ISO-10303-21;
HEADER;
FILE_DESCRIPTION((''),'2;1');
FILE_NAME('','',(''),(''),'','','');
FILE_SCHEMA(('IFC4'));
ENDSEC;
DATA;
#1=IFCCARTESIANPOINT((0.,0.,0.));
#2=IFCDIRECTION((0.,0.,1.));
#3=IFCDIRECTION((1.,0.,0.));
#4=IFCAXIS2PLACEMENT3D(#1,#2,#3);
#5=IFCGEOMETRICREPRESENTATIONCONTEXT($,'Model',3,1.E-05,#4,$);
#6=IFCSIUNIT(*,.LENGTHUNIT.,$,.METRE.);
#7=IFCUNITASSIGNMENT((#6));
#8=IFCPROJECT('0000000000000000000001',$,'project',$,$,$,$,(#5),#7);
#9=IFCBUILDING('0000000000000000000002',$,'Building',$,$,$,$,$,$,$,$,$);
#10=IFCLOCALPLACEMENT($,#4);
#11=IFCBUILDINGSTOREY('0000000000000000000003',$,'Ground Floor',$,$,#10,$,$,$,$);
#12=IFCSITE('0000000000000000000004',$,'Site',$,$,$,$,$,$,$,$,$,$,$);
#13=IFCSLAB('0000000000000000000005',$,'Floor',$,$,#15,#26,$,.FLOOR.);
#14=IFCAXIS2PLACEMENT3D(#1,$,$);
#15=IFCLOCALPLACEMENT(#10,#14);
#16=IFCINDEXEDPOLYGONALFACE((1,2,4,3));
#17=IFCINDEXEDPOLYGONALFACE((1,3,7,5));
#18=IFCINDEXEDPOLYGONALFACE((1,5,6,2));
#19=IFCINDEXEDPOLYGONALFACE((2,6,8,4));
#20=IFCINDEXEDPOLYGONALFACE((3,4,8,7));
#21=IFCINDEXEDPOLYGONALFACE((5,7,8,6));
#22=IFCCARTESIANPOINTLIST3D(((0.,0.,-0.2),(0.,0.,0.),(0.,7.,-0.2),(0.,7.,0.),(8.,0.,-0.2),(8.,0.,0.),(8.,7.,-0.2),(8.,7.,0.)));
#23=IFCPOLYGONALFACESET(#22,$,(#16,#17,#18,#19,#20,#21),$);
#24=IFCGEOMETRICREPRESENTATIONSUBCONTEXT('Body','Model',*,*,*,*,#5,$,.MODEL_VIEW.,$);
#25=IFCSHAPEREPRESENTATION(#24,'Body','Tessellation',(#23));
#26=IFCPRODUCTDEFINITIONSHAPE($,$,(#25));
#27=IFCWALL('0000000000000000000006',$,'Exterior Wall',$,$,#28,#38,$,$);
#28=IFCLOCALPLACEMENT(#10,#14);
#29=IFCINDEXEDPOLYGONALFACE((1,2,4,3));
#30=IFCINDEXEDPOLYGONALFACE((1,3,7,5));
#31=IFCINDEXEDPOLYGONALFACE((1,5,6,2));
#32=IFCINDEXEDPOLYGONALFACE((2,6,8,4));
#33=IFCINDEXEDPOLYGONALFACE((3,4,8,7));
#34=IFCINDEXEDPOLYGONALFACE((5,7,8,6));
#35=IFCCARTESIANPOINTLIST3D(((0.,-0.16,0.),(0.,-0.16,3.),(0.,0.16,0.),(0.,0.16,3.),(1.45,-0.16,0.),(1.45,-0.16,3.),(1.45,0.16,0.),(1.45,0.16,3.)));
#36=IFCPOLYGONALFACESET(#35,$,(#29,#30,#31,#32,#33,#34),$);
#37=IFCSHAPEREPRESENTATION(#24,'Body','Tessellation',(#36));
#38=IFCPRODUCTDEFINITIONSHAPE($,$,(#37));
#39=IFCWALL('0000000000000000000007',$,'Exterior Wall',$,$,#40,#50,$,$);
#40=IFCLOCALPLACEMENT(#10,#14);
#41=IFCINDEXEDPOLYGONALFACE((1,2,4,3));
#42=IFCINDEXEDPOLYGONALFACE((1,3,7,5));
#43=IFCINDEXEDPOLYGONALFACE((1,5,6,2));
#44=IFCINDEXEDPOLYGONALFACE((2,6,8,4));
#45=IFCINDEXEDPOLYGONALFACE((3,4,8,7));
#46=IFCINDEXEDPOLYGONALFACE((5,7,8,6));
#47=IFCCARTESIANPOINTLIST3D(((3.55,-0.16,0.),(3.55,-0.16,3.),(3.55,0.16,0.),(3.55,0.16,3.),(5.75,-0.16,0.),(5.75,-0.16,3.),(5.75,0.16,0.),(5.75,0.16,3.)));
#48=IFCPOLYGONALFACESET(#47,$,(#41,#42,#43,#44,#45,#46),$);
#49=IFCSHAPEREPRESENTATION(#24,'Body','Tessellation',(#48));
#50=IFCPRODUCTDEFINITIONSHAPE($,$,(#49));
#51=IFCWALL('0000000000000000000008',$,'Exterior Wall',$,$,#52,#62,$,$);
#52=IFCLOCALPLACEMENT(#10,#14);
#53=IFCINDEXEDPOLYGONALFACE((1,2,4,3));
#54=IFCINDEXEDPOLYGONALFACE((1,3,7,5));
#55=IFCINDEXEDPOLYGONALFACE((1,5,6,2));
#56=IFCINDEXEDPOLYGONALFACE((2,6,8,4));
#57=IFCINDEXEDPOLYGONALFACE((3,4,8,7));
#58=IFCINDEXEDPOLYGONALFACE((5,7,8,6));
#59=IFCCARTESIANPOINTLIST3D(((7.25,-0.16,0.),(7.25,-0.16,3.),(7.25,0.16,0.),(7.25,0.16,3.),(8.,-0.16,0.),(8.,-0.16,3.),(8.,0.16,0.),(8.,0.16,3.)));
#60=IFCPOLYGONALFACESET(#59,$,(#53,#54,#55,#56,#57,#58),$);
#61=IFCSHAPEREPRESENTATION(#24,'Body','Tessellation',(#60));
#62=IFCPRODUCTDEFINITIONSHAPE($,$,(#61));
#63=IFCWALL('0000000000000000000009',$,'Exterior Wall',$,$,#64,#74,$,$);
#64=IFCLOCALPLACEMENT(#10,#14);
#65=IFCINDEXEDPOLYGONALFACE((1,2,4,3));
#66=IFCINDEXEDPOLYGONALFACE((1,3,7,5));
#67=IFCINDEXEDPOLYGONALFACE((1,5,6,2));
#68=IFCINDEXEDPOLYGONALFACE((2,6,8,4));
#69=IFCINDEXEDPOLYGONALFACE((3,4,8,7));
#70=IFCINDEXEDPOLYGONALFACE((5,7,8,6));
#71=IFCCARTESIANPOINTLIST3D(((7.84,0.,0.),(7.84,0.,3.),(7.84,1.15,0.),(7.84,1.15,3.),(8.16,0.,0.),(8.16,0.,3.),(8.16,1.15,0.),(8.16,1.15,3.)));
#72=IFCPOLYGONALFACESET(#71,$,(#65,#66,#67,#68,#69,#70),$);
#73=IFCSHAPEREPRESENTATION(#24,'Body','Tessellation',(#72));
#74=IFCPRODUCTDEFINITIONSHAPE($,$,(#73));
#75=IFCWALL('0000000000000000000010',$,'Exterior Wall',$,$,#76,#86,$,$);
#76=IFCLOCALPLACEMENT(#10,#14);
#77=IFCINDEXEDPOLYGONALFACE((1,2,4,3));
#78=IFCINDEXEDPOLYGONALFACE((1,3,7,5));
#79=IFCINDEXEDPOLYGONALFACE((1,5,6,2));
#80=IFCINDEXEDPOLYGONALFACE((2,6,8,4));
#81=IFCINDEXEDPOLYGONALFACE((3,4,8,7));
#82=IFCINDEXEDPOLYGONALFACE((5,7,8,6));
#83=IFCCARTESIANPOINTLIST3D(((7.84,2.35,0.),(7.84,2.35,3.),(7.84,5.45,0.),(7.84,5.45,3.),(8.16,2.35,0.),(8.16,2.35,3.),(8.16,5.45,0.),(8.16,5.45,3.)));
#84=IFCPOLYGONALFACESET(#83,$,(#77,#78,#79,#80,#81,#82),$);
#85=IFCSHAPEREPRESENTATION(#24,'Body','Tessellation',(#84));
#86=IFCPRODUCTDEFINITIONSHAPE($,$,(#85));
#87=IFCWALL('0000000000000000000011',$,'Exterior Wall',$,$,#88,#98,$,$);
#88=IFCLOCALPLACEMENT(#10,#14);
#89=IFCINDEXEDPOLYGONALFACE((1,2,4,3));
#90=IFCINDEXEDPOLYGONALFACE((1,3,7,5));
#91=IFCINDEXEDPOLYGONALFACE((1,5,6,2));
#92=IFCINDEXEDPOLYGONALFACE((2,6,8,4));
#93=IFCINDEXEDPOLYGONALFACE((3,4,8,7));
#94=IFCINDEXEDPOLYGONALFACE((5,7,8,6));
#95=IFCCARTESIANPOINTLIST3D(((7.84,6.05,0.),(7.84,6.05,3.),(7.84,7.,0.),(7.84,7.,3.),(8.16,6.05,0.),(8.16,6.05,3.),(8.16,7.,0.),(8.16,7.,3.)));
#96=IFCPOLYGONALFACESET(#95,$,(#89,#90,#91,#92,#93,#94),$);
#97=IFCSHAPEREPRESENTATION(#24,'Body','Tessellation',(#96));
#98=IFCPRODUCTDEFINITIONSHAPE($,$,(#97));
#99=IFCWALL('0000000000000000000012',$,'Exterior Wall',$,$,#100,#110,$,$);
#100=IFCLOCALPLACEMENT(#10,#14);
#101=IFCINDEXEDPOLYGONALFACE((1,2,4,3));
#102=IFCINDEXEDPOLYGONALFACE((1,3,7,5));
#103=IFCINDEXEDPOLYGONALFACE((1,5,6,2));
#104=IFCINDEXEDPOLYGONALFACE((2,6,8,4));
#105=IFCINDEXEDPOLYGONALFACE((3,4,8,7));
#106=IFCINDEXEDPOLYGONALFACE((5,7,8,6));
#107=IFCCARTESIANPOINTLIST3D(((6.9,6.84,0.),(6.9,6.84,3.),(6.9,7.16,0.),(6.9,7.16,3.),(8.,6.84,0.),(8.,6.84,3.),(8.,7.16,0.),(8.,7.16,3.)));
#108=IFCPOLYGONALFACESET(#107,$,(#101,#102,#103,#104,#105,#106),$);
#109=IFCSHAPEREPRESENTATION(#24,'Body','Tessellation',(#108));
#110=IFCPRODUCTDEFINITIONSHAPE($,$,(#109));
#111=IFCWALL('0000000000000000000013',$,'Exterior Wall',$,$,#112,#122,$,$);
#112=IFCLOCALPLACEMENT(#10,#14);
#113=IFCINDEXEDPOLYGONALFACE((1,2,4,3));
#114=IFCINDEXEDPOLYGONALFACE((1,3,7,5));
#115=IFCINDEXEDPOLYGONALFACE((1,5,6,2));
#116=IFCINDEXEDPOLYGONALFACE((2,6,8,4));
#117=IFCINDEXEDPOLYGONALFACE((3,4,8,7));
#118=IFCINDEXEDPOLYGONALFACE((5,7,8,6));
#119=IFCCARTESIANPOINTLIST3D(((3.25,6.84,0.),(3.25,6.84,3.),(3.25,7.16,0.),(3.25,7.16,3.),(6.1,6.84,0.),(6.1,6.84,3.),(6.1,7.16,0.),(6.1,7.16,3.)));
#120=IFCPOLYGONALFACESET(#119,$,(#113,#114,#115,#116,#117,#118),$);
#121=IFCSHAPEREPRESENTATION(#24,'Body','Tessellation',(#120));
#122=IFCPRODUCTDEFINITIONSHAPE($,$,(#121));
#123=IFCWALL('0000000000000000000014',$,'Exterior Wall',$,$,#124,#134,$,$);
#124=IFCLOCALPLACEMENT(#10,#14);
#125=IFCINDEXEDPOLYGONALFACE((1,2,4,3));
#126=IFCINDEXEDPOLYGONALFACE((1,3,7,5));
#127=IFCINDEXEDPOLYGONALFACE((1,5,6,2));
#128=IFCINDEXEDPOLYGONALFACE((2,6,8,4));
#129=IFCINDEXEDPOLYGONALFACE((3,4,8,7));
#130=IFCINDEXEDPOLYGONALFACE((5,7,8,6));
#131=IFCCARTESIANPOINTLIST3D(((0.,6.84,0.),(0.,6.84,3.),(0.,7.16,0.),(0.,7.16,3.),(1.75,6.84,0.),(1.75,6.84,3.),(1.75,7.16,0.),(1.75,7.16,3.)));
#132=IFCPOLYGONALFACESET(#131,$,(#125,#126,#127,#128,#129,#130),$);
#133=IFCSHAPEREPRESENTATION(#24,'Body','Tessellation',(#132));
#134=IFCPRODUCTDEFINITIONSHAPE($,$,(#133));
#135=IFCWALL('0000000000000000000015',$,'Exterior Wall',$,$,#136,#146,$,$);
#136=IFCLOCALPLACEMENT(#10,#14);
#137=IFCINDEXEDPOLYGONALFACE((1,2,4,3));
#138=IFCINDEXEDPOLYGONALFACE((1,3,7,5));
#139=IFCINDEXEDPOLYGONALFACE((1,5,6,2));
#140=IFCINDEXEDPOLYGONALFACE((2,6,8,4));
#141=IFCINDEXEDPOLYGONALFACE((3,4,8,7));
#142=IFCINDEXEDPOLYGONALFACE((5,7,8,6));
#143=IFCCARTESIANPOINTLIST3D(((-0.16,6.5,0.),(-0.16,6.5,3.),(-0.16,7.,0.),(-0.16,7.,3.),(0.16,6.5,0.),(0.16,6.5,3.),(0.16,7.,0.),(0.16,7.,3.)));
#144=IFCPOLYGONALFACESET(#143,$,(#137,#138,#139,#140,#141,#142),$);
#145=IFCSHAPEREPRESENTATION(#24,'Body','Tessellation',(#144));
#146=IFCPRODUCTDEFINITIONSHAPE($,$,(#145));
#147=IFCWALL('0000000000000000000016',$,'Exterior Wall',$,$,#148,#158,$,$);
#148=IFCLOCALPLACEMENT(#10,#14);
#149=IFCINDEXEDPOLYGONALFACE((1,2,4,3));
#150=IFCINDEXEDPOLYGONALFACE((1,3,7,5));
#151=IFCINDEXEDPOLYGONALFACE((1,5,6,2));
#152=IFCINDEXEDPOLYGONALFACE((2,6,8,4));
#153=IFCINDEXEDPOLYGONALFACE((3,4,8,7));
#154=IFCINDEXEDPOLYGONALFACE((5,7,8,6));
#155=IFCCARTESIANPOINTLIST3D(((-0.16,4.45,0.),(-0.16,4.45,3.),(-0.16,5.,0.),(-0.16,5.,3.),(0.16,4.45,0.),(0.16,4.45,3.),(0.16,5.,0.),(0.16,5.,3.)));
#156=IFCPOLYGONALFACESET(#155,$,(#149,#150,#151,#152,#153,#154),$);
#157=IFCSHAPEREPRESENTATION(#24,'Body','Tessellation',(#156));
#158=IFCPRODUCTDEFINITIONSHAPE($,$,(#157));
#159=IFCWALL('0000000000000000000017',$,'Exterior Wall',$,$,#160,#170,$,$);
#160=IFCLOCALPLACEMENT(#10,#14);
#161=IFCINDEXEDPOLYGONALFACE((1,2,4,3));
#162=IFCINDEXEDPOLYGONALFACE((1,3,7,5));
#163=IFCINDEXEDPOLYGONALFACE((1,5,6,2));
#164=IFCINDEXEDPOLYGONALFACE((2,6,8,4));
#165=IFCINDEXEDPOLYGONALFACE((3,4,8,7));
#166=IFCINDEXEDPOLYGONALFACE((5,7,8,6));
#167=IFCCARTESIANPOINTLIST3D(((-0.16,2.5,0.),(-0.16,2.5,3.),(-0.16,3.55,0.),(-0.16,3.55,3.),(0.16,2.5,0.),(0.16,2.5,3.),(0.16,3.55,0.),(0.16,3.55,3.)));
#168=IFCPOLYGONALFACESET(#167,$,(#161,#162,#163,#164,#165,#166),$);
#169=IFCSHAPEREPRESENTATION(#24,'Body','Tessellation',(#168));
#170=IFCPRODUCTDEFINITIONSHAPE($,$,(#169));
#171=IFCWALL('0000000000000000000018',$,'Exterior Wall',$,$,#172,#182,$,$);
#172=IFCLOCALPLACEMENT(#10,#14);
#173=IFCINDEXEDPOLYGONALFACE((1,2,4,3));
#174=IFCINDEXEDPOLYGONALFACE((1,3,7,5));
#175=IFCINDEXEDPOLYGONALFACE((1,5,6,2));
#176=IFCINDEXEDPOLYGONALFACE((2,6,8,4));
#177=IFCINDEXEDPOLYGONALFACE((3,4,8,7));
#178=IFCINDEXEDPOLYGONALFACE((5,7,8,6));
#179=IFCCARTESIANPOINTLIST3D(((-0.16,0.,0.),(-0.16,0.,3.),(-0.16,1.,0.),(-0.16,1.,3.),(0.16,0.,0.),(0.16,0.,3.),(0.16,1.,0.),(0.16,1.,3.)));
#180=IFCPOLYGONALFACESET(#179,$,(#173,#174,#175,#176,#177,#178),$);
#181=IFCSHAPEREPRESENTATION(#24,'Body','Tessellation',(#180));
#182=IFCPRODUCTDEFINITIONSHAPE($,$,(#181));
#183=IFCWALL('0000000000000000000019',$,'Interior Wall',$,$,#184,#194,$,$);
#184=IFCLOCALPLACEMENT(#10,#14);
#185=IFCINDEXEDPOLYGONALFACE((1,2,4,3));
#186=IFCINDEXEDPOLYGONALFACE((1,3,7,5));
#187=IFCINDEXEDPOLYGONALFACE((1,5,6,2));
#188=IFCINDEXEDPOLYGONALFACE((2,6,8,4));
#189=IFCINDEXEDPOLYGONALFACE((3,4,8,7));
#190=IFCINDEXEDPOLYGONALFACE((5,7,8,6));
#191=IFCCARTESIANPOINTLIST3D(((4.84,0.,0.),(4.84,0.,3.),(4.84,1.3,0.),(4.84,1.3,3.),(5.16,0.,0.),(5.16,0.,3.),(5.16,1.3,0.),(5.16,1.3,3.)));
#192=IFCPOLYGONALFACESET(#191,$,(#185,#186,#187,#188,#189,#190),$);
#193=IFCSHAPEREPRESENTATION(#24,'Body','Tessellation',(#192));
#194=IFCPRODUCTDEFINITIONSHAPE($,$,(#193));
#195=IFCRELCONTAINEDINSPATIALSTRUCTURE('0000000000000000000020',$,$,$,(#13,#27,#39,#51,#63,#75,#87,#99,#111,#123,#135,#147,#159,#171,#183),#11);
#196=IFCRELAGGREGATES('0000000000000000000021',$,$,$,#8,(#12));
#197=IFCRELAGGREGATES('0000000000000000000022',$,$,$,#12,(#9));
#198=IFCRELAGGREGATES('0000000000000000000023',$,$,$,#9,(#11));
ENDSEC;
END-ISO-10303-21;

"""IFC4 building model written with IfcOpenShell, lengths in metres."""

from ifc_helpers import new_model, si_unit, frame, origin_with_axes, place, context, subcontext, project, spatial, indexed_curve, outline, extrude, element, save


model = new_model("IFC4")

# Units and contexts
model_context = context("Model", 3, precision=1e-05, world=origin_with_axes())
body_context = subcontext(model_context, "Body", "Model", "MODEL_VIEW")
ifc_project = project(units=[si_unit("LENGTHUNIT", "METRE")], contexts=[model_context])

# Site, building, storey
site = spatial("IfcSite", under=ifc_project, Name="Site")
building = spatial("IfcBuilding", under=site, Name="Building")
storey_placement = place(None, origin_with_axes())
storey = spatial("IfcBuildingStorey", under=building, at=storey_placement, Name="Ground Floor")

# Slab
slab_placement = place(storey_placement, frame((0.0, 0.0, -0.2), z_axis=(0.0, 0.0, 1.0), x_axis=(1.0, 0.0, 0.0)))
element("IfcSlab", 1, at=slab_placement, inside=storey, Name="Floor", PredefinedType="FLOOR", context=body_context, shape_type="SweptSolid", body=[
    extrude(outline(indexed_curve([(0.0, 0.0), (8.0, 0.0), (8.0, 7.0), (0.0, 7.0)])), None, (0.0, 0.0, 1.0), 0.2),
])

# Walls
wall_1_placement = place(storey_placement, origin_with_axes())
element("IfcWall", 2, at=wall_1_placement, inside=storey, Name="Exterior Wall", context=body_context, shape_type="SweptSolid", body=[
    extrude(outline(indexed_curve([(0.0, 0.0), (0.0, 0.32), (1.45, 0.32), (1.45, 0.0), (0.0, 0.0)], self_intersect=False)), frame((0.0, -0.16, 0.0), z_axis=(0.0, 0.0, 1.0), x_axis=(1.0, 0.0, 0.0)), (0.0, 0.0, 1.0), 3.0),
])
wall_2_placement = place(storey_placement, frame((3.55, 0.0, 0.0), z_axis=(0.0, 0.0, 1.0), x_axis=(1.0, 0.0, 0.0)))
element("IfcWall", 3, at=wall_2_placement, inside=storey, Name="Exterior Wall", context=body_context, shape_type="SweptSolid", body=[
    extrude(outline(indexed_curve([(0.0, 0.0), (0.0, 0.32), (2.2, 0.32), (2.2, 0.0), (0.0, 0.0)], self_intersect=False)), frame((0.0, -0.16, 0.0), z_axis=(0.0, 0.0, 1.0), x_axis=(1.0, 0.0, 0.0)), (0.0, 0.0, 1.0), 3.0),
])
wall_3_placement = place(storey_placement, frame((7.25, 0.0, 0.0), z_axis=(0.0, 0.0, 1.0), x_axis=(1.0, 0.0, 0.0)))
element("IfcWall", 4, at=wall_3_placement, inside=storey, Name="Exterior Wall", context=body_context, shape_type="SweptSolid", body=[
    extrude(outline(indexed_curve([(0.0, 0.0), (0.0, 0.32), (0.75, 0.32), (0.75, 0.0), (0.0, 0.0)], self_intersect=False)), frame((0.0, -0.16, 0.0), z_axis=(0.0, 0.0, 1.0), x_axis=(1.0, 0.0, 0.0)), (0.0, 0.0, 1.0), 3.0),
])
wall_4_placement = place(storey_placement, frame((8.0, 0.0, 0.0), z_axis=(0.0, 0.0, 1.0), x_axis=(0.0, 1.0, 0.0)))
element("IfcWall", 5, at=wall_4_placement, inside=storey, Name="Exterior Wall", context=body_context, shape_type="SweptSolid", body=[
    extrude(outline(indexed_curve([(0.0, 0.0), (0.0, 0.32), (1.15, 0.32), (1.15, 0.0), (0.0, 0.0)], self_intersect=False)), frame((0.0, -0.16, 0.0), z_axis=(0.0, 0.0, 1.0), x_axis=(1.0, 0.0, 0.0)), (0.0, 0.0, 1.0), 3.0),
])
wall_5_placement = place(storey_placement, frame((8.0, 2.35, 0.0), z_axis=(0.0, 0.0, 1.0), x_axis=(0.0, 1.0, 0.0)))
element("IfcWall", 6, at=wall_5_placement, inside=storey, Name="Exterior Wall", context=body_context, shape_type="SweptSolid", body=[
    extrude(outline(indexed_curve([(0.0, 0.0), (0.0, 0.32), (3.1, 0.32), (3.1, 0.0), (0.0, 0.0)], self_intersect=False)), frame((0.0, -0.16, 0.0), z_axis=(0.0, 0.0, 1.0), x_axis=(1.0, 0.0, 0.0)), (0.0, 0.0, 1.0), 3.0),
])
wall_6_placement = place(storey_placement, frame((8.0, 6.05, 0.0), z_axis=(0.0, 0.0, 1.0), x_axis=(0.0, 1.0, 0.0)))
element("IfcWall", 7, at=wall_6_placement, inside=storey, Name="Exterior Wall", context=body_context, shape_type="SweptSolid", body=[
    extrude(outline(indexed_curve([(0.0, 0.0), (0.0, 0.32), (0.95, 0.32), (0.95, 0.0), (0.0, 0.0)], self_intersect=False)), frame((0.0, -0.16, 0.0), z_axis=(0.0, 0.0, 1.0), x_axis=(1.0, 0.0, 0.0)), (0.0, 0.0, 1.0), 3.0),
])
wall_7_placement = place(storey_placement, frame((8.0, 7.0, 0.0), z_axis=(0.0, 0.0, 1.0), x_axis=(-1.0, 0.0, 0.0)))
element("IfcWall", 8, at=wall_7_placement, inside=storey, Name="Exterior Wall", context=body_context, shape_type="SweptSolid", body=[
    extrude(outline(indexed_curve([(0.0, 0.0), (0.0, 0.32), (1.1, 0.32), (1.1, 0.0), (0.0, 0.0)], self_intersect=False)), frame((0.0, -0.16, 0.0), z_axis=(0.0, 0.0, 1.0), x_axis=(1.0, 0.0, 0.0)), (0.0, 0.0, 1.0), 3.0),
])
wall_8_placement = place(storey_placement, frame((6.1, 7.0, 0.0), z_axis=(0.0, 0.0, 1.0), x_axis=(-1.0, 0.0, 0.0)))
element("IfcWall", 9, at=wall_8_placement, inside=storey, Name="Exterior Wall", context=body_context, shape_type="SweptSolid", body=[
    extrude(outline(indexed_curve([(0.0, 0.0), (0.0, 0.32), (2.85, 0.32), (2.85, 0.0), (0.0, 0.0)], self_intersect=False)), frame((0.0, -0.16, 0.0), z_axis=(0.0, 0.0, 1.0), x_axis=(1.0, 0.0, 0.0)), (0.0, 0.0, 1.0), 3.0),
])
wall_9_placement = place(storey_placement, frame((1.75, 7.0, 0.0), z_axis=(0.0, 0.0, 1.0), x_axis=(-1.0, 0.0, 0.0)))
element("IfcWall", 10, at=wall_9_placement, inside=storey, Name="Exterior Wall", context=body_context, shape_type="SweptSolid", body=[
    extrude(outline(indexed_curve([(0.0, 0.0), (0.0, 0.32), (1.75, 0.32), (1.75, 0.0), (0.0, 0.0)], self_intersect=False)), frame((0.0, -0.16, 0.0), z_axis=(0.0, 0.0, 1.0), x_axis=(1.0, 0.0, 0.0)), (0.0, 0.0, 1.0), 3.0),
])
wall_10_placement = place(storey_placement, frame((0.0, 7.0, 0.0), z_axis=(0.0, 0.0, 1.0), x_axis=(0.0, -1.0, 0.0)))
element("IfcWall", 11, at=wall_10_placement, inside=storey, Name="Exterior Wall", context=body_context, shape_type="SweptSolid", body=[
    extrude(outline(indexed_curve([(0.0, 0.0), (0.0, 0.32), (0.5, 0.32), (0.5, 0.0), (0.0, 0.0)], self_intersect=False)), frame((0.0, -0.16, 0.0), z_axis=(0.0, 0.0, 1.0), x_axis=(1.0, 0.0, 0.0)), (0.0, 0.0, 1.0), 3.0),
])
wall_11_placement = place(storey_placement, frame((0.0, 5.0, 0.0), z_axis=(0.0, 0.0, 1.0), x_axis=(0.0, -1.0, 0.0)))
element("IfcWall", 12, at=wall_11_placement, inside=storey, Name="Exterior Wall", context=body_context, shape_type="SweptSolid", body=[
    extrude(outline(indexed_curve([(0.0, 0.0), (0.0, 0.32), (0.55, 0.32), (0.55, 0.0), (0.0, 0.0)], self_intersect=False)), frame((0.0, -0.16, 0.0), z_axis=(0.0, 0.0, 1.0), x_axis=(1.0, 0.0, 0.0)), (0.0, 0.0, 1.0), 3.0),
])
wall_12_placement = place(storey_placement, frame((0.0, 3.55, 0.0), z_axis=(0.0, 0.0, 1.0), x_axis=(0.0, -1.0, 0.0)))
element("IfcWall", 13, at=wall_12_placement, inside=storey, Name="Exterior Wall", context=body_context, shape_type="SweptSolid", body=[
    extrude(outline(indexed_curve([(0.0, 0.0), (0.0, 0.32), (1.05, 0.32), (1.05, 0.0), (0.0, 0.0)], self_intersect=False)), frame((0.0, -0.16, 0.0), z_axis=(0.0, 0.0, 1.0), x_axis=(1.0, 0.0, 0.0)), (0.0, 0.0, 1.0), 3.0),
])
wall_13_placement = place(storey_placement, frame((0.0, 1.0, 0.0), z_axis=(0.0, 0.0, 1.0), x_axis=(0.0, -1.0, 0.0)))
element("IfcWall", 14, at=wall_13_placement, inside=storey, Name="Exterior Wall", context=body_context, shape_type="SweptSolid", body=[
    extrude(outline(indexed_curve([(0.0, 0.0), (0.0, 0.32), (1.0, 0.32), (1.0, 0.0), (0.0, 0.0)], self_intersect=False)), frame((0.0, -0.16, 0.0), z_axis=(0.0, 0.0, 1.0), x_axis=(1.0, 0.0, 0.0)), (0.0, 0.0, 1.0), 3.0),
])
wall_14_placement = place(storey_placement, frame((5.0, 0.0, 0.0), z_axis=(0.0, 0.0, 1.0), x_axis=(0.0, 1.0, 0.0)))
element("IfcWall", 15, at=wall_14_placement, inside=storey, Name="Interior Wall", context=body_context, shape_type="SweptSolid", body=[
    extrude(outline(indexed_curve([(0.0, 0.0), (0.0, 0.32), (1.3, 0.32), (1.3, 0.0), (0.0, 0.0)], self_intersect=False)), frame((0.0, -0.16, 0.0), z_axis=(0.0, 0.0, 1.0), x_axis=(1.0, 0.0, 0.0)), (0.0, 0.0, 1.0), 3.0),
])

save(model, "model.ifc")
